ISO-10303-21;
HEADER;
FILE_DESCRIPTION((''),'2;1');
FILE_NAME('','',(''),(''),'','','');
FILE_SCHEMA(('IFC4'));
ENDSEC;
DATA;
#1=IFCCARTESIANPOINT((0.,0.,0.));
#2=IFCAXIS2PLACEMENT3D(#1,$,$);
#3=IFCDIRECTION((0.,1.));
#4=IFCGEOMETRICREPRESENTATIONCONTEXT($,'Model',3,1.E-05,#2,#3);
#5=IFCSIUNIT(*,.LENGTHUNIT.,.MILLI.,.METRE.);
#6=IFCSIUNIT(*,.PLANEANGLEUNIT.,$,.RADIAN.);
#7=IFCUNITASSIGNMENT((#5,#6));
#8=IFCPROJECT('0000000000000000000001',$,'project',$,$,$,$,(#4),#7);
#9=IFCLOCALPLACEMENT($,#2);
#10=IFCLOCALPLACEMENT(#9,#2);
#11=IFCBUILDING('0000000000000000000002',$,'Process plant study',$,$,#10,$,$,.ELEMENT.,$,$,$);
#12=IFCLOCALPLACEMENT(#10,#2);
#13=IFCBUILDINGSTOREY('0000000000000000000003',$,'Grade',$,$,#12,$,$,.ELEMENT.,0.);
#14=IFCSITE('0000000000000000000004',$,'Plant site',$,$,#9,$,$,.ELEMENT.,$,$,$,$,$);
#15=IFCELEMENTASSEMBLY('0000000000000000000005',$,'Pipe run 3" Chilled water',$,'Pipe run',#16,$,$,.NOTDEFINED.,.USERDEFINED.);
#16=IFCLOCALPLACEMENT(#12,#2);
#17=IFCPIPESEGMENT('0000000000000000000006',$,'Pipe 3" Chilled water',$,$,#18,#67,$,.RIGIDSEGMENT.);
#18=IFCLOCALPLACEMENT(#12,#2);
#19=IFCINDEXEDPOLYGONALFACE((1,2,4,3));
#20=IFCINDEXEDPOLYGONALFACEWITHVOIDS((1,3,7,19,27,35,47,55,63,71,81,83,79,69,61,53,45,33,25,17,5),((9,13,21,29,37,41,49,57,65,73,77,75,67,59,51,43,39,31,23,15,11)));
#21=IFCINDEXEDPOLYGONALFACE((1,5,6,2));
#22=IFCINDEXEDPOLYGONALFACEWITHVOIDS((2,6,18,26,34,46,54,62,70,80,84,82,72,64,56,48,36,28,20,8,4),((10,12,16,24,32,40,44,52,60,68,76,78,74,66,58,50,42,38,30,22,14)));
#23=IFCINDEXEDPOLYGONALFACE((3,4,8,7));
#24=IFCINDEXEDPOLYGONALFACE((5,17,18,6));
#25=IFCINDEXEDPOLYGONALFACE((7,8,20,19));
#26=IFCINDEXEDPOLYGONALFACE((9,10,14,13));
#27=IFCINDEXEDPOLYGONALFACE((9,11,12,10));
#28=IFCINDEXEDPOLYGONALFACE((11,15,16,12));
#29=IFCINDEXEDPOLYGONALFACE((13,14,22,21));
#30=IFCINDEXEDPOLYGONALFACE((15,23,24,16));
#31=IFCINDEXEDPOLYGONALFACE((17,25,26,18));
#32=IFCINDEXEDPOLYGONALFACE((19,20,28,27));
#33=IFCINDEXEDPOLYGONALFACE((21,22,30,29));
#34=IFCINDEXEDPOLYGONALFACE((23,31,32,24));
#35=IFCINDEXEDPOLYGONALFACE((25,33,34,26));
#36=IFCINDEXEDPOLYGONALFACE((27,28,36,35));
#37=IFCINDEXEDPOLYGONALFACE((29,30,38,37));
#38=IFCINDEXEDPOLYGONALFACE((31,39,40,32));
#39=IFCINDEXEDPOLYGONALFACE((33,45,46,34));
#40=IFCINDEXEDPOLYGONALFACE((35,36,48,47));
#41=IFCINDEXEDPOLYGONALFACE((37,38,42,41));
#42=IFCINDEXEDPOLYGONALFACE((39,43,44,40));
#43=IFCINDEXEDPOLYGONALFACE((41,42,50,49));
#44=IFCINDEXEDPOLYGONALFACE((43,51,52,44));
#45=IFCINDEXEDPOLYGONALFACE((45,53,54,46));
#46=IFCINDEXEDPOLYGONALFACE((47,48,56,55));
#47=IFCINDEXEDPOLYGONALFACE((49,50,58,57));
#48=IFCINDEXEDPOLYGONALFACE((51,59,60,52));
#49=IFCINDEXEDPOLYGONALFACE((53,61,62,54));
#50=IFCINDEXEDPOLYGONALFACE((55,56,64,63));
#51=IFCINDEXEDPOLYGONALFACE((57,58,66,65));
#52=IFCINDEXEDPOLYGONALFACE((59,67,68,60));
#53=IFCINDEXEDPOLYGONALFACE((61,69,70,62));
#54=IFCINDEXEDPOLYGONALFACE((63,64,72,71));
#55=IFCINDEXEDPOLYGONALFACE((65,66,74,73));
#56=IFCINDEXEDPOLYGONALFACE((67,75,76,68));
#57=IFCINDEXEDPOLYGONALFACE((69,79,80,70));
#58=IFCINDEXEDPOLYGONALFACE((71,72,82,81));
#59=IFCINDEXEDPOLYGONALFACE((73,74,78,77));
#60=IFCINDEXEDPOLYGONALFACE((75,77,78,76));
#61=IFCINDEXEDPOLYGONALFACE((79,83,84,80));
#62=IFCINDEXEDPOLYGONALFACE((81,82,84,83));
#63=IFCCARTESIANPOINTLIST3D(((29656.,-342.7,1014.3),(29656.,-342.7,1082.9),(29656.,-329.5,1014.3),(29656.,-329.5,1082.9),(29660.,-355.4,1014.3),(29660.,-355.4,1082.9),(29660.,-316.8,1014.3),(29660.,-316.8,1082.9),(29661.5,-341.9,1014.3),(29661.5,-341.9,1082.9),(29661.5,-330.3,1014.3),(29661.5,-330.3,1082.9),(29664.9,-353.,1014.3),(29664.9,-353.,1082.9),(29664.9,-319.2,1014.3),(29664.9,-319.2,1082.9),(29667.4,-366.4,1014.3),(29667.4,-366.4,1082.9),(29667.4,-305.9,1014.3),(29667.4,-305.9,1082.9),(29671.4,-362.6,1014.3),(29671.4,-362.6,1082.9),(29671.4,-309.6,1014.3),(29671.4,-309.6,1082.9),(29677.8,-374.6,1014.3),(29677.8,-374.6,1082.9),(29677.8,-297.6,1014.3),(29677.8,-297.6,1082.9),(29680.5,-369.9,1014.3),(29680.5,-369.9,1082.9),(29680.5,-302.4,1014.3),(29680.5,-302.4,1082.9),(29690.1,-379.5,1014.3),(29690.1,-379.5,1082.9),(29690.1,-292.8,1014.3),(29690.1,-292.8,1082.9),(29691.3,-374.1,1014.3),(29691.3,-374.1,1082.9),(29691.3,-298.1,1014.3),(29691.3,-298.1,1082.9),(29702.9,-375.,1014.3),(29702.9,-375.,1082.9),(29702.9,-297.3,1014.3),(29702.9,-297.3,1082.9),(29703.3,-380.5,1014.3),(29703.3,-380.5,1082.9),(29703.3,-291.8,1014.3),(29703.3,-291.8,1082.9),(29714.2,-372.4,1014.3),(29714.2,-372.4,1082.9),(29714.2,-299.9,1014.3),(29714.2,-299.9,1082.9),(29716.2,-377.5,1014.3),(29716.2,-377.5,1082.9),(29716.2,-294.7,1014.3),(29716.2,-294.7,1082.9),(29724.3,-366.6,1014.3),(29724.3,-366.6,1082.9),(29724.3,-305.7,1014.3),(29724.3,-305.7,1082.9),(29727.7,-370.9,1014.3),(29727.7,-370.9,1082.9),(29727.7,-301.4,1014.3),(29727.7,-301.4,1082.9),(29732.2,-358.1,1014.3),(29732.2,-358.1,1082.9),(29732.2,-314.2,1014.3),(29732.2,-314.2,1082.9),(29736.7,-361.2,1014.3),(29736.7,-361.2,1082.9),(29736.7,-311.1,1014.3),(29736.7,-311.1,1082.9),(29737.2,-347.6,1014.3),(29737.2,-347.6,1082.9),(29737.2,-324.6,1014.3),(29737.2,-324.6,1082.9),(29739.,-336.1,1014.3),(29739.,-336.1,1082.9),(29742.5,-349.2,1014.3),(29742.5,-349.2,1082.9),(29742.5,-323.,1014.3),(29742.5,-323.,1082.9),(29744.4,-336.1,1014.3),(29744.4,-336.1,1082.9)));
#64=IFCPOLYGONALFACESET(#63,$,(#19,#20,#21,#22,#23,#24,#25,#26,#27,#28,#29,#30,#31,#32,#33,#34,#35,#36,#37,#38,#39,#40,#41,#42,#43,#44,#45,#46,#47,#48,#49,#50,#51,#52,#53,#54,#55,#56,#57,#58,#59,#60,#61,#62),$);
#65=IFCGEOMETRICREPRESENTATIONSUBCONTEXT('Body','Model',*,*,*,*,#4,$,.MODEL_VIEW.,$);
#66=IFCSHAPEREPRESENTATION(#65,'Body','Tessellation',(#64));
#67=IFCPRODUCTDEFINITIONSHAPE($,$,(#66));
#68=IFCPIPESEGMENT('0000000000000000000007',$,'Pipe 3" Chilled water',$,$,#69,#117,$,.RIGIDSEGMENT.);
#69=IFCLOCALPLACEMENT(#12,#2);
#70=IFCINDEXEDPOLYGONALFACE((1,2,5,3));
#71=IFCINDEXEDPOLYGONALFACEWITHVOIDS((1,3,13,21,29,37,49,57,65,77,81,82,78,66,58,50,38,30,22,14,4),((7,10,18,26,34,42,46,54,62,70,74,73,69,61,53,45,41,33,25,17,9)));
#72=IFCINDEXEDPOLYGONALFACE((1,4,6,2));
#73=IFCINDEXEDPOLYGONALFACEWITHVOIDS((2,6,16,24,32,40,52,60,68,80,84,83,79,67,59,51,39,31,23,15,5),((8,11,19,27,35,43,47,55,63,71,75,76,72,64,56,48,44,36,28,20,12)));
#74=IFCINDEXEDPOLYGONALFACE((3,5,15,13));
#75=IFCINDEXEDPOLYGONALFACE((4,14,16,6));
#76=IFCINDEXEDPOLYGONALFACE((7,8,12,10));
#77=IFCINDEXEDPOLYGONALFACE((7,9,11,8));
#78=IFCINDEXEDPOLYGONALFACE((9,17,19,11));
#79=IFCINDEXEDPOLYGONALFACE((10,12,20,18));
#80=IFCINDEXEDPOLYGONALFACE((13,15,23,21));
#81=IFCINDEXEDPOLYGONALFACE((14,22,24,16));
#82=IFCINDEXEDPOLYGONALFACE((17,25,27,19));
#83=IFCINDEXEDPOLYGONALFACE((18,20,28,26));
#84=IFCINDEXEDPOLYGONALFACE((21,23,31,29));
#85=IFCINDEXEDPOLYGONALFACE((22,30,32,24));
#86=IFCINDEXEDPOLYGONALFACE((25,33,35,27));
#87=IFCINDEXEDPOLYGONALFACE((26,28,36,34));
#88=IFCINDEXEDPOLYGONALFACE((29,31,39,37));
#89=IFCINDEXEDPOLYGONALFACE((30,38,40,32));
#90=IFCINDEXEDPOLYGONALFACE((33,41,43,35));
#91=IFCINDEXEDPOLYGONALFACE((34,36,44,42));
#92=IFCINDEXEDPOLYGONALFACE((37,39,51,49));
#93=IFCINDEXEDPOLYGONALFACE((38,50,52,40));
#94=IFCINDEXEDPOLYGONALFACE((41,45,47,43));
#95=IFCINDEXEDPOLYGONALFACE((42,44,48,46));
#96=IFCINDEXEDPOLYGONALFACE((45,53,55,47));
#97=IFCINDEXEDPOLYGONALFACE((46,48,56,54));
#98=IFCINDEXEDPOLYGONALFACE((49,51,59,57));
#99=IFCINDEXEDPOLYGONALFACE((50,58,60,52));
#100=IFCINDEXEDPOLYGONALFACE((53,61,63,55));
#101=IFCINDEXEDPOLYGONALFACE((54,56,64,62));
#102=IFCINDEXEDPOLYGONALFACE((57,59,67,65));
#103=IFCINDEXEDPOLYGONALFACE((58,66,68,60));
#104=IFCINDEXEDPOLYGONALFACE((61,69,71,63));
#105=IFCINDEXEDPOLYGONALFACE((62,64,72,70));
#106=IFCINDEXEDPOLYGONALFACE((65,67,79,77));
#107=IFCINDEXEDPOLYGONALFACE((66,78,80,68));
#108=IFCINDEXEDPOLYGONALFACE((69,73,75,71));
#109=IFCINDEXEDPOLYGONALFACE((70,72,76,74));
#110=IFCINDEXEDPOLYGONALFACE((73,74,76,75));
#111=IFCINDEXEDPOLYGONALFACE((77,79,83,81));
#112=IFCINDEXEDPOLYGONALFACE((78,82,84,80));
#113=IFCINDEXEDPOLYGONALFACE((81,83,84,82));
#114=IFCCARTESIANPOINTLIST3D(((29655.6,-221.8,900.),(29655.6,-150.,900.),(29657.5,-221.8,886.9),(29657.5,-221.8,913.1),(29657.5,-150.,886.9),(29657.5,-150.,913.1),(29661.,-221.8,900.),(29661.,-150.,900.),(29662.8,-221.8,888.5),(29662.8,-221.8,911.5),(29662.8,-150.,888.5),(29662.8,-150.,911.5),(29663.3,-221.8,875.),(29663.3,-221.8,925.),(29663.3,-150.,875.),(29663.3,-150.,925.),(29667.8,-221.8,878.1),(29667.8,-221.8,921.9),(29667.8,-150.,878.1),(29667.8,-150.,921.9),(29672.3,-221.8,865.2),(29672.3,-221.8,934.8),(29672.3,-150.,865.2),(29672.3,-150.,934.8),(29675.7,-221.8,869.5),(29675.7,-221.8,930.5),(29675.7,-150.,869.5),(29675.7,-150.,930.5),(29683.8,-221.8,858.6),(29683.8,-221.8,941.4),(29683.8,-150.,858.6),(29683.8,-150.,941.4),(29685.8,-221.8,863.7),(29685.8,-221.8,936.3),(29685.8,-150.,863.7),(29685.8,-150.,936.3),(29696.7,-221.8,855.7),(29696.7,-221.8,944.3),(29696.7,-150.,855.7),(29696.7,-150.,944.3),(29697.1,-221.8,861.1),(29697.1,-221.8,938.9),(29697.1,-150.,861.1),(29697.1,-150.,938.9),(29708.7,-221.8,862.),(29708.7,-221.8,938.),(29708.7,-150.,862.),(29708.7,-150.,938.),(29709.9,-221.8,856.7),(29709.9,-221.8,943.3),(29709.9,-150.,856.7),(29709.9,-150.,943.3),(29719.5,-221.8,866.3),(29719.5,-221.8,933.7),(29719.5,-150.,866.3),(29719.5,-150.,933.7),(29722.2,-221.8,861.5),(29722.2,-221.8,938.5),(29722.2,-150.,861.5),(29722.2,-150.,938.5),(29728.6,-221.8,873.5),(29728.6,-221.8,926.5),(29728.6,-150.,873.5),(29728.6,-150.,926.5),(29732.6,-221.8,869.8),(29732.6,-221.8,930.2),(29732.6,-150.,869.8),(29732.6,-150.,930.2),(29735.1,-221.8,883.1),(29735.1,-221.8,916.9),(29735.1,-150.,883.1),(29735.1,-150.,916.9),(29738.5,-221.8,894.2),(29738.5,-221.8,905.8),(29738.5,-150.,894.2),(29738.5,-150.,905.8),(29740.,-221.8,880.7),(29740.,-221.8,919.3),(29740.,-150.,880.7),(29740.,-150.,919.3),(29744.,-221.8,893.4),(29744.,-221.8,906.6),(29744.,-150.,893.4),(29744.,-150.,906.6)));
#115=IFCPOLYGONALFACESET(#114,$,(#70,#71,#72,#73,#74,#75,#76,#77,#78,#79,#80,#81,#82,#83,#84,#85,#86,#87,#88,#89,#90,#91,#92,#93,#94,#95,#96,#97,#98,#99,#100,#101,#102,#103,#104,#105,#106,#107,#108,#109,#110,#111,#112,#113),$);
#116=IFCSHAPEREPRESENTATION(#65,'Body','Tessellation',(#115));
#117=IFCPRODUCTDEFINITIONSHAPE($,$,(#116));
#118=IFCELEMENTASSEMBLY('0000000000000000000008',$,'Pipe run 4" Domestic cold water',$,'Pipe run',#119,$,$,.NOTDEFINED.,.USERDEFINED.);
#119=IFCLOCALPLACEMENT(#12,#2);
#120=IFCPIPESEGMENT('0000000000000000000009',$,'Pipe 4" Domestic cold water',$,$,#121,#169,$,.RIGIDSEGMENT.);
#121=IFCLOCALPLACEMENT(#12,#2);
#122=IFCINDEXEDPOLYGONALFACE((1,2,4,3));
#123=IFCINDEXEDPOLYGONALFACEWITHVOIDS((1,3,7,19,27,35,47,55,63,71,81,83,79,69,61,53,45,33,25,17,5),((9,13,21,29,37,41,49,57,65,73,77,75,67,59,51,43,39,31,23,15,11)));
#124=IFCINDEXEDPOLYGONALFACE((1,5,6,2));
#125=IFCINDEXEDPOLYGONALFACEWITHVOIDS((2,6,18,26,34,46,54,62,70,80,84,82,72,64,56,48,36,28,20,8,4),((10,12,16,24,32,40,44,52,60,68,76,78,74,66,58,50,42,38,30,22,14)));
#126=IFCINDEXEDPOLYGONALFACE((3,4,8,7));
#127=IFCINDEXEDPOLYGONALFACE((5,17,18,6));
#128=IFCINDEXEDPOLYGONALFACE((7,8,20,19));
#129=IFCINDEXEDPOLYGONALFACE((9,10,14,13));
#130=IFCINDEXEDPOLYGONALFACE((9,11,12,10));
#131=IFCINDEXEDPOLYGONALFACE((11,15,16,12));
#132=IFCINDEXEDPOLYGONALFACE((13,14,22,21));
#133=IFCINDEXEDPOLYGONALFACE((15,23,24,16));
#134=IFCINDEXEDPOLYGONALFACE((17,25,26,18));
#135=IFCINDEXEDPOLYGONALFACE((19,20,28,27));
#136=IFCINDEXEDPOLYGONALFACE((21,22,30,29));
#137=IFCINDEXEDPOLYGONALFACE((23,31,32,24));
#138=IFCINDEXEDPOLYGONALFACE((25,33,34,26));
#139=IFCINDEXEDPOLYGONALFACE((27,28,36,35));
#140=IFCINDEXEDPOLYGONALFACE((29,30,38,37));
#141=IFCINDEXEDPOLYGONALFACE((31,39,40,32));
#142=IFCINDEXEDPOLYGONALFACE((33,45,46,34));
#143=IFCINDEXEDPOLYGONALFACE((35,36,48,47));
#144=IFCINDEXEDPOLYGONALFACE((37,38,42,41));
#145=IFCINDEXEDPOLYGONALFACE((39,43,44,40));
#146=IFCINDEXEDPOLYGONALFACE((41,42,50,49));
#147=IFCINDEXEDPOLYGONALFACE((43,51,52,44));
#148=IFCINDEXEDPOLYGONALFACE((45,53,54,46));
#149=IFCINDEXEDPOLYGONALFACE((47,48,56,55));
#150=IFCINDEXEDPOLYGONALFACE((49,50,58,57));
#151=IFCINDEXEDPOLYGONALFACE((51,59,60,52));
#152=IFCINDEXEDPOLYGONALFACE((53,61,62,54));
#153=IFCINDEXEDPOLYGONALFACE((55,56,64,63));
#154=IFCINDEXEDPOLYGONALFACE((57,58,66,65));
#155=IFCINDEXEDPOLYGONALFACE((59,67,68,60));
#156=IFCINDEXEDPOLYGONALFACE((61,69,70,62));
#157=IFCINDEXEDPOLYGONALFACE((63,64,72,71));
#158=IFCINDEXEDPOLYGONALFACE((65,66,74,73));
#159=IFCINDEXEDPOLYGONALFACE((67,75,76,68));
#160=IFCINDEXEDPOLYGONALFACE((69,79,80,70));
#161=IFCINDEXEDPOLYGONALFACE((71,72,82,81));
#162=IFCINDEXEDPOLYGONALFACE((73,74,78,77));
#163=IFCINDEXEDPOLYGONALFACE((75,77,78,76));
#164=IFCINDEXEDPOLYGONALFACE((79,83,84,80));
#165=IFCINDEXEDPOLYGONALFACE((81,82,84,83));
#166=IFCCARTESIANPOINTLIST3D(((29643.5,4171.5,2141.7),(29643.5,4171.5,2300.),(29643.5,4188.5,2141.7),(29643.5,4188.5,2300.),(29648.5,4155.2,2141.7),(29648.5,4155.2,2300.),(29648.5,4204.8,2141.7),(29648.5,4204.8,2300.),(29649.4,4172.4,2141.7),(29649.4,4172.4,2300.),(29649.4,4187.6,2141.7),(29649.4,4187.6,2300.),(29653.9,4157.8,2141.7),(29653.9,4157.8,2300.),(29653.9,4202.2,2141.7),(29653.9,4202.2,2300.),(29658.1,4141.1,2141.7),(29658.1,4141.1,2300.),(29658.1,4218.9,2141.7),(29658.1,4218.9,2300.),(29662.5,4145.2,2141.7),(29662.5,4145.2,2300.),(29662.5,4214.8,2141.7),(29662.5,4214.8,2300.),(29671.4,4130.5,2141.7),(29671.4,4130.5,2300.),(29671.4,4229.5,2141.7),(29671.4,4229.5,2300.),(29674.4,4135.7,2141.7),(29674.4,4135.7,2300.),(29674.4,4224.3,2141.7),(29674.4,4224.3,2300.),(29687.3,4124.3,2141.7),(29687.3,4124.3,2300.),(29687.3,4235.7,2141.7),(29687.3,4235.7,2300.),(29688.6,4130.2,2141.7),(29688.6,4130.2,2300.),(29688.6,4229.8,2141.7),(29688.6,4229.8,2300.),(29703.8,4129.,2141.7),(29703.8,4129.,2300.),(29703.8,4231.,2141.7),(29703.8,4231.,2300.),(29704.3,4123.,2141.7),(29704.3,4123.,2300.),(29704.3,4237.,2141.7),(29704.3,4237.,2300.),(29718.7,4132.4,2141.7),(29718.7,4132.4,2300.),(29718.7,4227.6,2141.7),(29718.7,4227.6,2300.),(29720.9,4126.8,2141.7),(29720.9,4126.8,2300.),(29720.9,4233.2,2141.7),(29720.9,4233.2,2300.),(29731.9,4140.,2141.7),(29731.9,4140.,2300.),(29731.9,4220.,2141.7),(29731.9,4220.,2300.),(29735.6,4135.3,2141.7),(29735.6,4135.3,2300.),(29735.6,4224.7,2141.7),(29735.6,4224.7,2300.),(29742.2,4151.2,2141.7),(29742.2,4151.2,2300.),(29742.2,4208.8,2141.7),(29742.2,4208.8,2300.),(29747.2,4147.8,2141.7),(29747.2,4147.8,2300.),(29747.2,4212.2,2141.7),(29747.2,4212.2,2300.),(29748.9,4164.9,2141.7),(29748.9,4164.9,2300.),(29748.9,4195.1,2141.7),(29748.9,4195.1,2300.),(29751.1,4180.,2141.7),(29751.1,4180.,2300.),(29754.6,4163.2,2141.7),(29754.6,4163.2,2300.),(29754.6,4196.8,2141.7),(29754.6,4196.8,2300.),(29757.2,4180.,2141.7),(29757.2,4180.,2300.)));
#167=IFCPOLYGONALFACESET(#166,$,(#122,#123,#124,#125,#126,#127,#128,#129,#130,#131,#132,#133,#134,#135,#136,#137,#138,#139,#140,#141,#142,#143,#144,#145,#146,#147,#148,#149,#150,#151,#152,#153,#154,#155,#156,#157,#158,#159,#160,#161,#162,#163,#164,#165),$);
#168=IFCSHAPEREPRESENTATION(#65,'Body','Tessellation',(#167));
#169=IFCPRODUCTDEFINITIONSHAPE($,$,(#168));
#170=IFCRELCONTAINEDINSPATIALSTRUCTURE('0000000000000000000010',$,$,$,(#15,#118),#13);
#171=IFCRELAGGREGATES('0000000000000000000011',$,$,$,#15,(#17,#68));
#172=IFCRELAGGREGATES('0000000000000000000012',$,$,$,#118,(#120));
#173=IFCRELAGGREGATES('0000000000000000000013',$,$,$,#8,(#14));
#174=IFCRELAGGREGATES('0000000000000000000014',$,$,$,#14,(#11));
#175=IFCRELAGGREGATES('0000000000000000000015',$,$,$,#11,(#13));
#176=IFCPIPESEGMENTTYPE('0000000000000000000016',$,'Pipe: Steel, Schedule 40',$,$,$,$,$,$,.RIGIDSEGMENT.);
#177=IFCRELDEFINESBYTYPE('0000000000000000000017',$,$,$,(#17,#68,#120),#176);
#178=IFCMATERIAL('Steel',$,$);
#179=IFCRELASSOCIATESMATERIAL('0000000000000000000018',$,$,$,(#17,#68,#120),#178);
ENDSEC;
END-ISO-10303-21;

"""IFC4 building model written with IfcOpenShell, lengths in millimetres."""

from ifc_helpers import new_model, si_unit, direction, frame, origin, origin_with_axes, origin_2d, place, context, subcontext, project, spatial, hollow_circle, extrude, material, type_object, element, aggregate, save


model = new_model("IFC4")

# Units and contexts
model_context = context("Model", 3, precision=1e-05, world=origin(), true_north=direction((0.0, 1.0)))
body_context = subcontext(model_context, "Body", "Model", "MODEL_VIEW")
ifc_project = project(units=[si_unit("LENGTHUNIT", "METRE", prefix="MILLI"), si_unit("PLANEANGLEUNIT", "RADIAN")], contexts=[model_context])

# Site, building, storey
site_placement = place(None, origin())
site = spatial("IfcSite", under=ifc_project, at=site_placement, Name="Plant site", CompositionType="ELEMENT")
building_placement = place(site_placement, origin())
building = spatial("IfcBuilding", under=site, at=building_placement, Name="Process plant study", CompositionType="ELEMENT")
storey_placement = place(building_placement, origin())
storey = spatial("IfcBuildingStorey", under=building, at=storey_placement, Name="Grade", CompositionType="ELEMENT", Elevation=0.0)

# Shared definitions
ifc_material = material(Name="Steel")
pipe_segment_type = type_object("IfcPipeSegmentType", Name="Pipe: Steel, Schedule 40", PredefinedType="RIGIDSEGMENT")

# Element assemblies, pipe segments
assembly_1_placement = place(storey_placement, origin_with_axes())
assembly_1 = element("IfcElementAssembly", 1, at=assembly_1_placement, inside=storey, Name="Pipe run 3\" Chilled water", ObjectType="Pipe run", AssemblyPlace="NOTDEFINED", PredefinedType="USERDEFINED")
pipe_segment_1_placement = place(storey_placement, origin_with_axes())
pipe_segment_1 = element("IfcPipeSegment", 2, at=pipe_segment_1_placement, type_object=pipe_segment_type, material=ifc_material, Name="Pipe 3\" Chilled water", PredefinedType="RIGIDSEGMENT", context=body_context, shape_type="SweptSolid", body=[
    extrude(hollow_circle(Radius=44.5, WallThickness=5.5, at=origin_2d()), frame((29700.0, -336.1, 1082.9), z_axis=(0.0, 0.0, -1.0), x_axis=(1.0, 0.0, 0.0)), (0.0, 0.0, 1.0), 68.6),
])
pipe_segment_2_placement = place(storey_placement, origin_with_axes())
pipe_segment_2 = element("IfcPipeSegment", 3, at=pipe_segment_2_placement, type_object=pipe_segment_type, material=ifc_material, Name="Pipe 3\" Chilled water", PredefinedType="RIGIDSEGMENT", context=body_context, shape_type="SweptSolid", body=[
    extrude(hollow_circle(Radius=44.5, WallThickness=5.5, at=origin_2d()), frame((29700.0, -221.8, 900.0), z_axis=(0.0, 1.0, 0.0), x_axis=(-1.0, 0.0, 0.0)), (0.0, 0.0, 1.0), 71.8),
])
assembly_2_placement = place(storey_placement, origin_with_axes())
assembly_2 = element("IfcElementAssembly", 4, at=assembly_2_placement, inside=storey, Name="Pipe run 4\" Domestic cold water", ObjectType="Pipe run", AssemblyPlace="NOTDEFINED", PredefinedType="USERDEFINED")
pipe_segment_3_placement = place(storey_placement, origin_with_axes())
pipe_segment_3 = element("IfcPipeSegment", 5, at=pipe_segment_3_placement, type_object=pipe_segment_type, material=ifc_material, Name="Pipe 4\" Domestic cold water", PredefinedType="RIGIDSEGMENT", context=body_context, shape_type="SweptSolid", body=[
    extrude(hollow_circle(Radius=57.1, WallThickness=6.0, at=origin_2d()), frame((29700.0, 4180.0, 2300.0), z_axis=(0.0, 0.0, -1.0), x_axis=(1.0, 0.0, 0.0)), (0.0, 0.0, 1.0), 158.3),
])

aggregate(assembly_1, [pipe_segment_1, pipe_segment_2])
aggregate(assembly_2, [pipe_segment_3])

save(model, "model.ifc")
